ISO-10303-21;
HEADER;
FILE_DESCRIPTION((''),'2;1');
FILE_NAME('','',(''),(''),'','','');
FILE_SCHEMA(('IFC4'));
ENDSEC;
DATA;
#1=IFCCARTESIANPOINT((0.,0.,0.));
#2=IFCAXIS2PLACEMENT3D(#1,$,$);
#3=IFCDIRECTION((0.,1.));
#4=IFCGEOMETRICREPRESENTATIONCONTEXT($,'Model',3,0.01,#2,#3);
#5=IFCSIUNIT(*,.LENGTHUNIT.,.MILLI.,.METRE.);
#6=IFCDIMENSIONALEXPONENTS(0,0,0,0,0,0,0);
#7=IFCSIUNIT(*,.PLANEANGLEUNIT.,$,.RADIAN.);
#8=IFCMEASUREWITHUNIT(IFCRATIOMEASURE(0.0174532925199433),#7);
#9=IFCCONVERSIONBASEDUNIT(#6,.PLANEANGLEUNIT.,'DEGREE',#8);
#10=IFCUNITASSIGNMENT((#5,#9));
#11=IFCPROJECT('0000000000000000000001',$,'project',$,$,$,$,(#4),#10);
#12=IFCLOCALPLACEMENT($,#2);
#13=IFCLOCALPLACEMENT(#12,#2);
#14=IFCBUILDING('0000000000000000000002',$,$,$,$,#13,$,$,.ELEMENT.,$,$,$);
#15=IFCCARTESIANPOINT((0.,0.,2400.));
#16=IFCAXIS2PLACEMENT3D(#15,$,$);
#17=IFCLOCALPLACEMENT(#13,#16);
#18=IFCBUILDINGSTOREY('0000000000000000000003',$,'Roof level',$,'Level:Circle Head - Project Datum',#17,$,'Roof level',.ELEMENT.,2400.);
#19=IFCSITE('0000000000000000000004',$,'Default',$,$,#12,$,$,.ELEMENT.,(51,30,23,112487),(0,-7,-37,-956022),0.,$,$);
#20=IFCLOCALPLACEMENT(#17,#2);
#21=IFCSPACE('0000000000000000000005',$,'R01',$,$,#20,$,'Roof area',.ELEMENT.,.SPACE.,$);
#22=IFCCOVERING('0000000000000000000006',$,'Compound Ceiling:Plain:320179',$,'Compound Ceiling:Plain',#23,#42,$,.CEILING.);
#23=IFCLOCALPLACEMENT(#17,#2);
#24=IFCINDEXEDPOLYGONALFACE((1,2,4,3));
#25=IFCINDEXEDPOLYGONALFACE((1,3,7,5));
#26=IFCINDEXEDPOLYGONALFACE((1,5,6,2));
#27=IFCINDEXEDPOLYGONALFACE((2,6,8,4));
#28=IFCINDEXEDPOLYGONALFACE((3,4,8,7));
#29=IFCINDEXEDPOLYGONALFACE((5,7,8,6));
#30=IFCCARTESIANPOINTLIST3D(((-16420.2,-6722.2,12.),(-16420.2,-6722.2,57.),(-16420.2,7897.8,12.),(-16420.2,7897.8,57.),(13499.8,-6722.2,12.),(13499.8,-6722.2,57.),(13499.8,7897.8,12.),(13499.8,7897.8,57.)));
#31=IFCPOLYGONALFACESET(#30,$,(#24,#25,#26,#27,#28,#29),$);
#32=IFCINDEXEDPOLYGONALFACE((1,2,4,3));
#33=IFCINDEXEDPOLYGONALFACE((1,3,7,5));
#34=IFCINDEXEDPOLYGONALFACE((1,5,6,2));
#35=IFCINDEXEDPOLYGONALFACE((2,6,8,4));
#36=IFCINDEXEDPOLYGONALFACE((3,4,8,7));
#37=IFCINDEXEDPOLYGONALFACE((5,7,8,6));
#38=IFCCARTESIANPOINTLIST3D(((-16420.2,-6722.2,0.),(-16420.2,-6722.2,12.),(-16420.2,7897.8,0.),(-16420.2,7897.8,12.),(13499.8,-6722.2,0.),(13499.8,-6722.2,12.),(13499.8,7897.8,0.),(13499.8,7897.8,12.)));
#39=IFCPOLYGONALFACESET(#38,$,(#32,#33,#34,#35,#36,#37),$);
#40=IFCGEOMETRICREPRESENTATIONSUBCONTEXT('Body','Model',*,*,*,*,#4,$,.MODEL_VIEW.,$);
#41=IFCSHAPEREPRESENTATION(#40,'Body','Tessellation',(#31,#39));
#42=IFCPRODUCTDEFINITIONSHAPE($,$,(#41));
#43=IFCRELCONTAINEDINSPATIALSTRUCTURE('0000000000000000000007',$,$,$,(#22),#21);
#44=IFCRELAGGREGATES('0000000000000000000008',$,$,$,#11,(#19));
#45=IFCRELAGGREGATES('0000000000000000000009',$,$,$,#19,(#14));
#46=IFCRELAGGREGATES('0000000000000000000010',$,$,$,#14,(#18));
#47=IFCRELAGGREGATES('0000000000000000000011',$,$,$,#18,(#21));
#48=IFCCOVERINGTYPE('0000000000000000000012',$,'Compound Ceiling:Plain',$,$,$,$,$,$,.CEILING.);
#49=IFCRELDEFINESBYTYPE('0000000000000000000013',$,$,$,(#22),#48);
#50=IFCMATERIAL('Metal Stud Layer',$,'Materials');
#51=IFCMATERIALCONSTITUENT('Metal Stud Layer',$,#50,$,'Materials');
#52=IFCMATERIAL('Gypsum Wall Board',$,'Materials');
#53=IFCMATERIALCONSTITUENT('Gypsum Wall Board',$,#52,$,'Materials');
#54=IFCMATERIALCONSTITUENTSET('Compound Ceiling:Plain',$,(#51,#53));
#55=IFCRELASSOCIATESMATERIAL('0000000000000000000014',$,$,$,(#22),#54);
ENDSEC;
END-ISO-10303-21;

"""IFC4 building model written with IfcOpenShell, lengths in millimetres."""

from ifc_helpers import new_model, entity, si_unit, converted_unit, direction, frame, origin, place, context, subcontext, project, spatial, indexed_curve, outline, extrude, material, constituent, constituent_set, type_object, element, save


model = new_model("IFC4")

# Units and contexts
model_context = context("Model", 3, precision=0.01, world=origin(), true_north=direction((0.0, 1.0)))
body_context = subcontext(model_context, "Body", "Model", "MODEL_VIEW")
ifc_project = project(units=[si_unit("LENGTHUNIT", "METRE", prefix="MILLI"), converted_unit("PLANEANGLEUNIT", "DEGREE", entity("IfcRatioMeasure", 0.0174532925199433), si_unit("PLANEANGLEUNIT", "RADIAN"), dimensions=[0, 0, 0, 0, 0, 0, 0])], contexts=[model_context])

# Site, building, storey, space
site_placement = place(None, origin())
site = spatial("IfcSite", under=ifc_project, at=site_placement, Name="Default", CompositionType="ELEMENT", RefLatitude=(51, 30, 23, 112487), RefLongitude=(0, -7, -37, -956022), RefElevation=0.0)
building_placement = place(site_placement, origin())
building = spatial("IfcBuilding", under=site, at=building_placement, CompositionType="ELEMENT")
storey_placement = place(building_placement, frame((0.0, 0.0, 2400.0)))
storey = spatial("IfcBuildingStorey", under=building, at=storey_placement, Name="Roof level", ObjectType="Level:Circle Head - Project Datum", LongName="Roof level", CompositionType="ELEMENT", Elevation=2400.0)
space_placement = place(storey_placement, origin())
space = spatial("IfcSpace", under=storey, at=space_placement, Name="R01", LongName="Roof area", CompositionType="ELEMENT", PredefinedType="SPACE")

# Covering
ifc_material_1 = material(Name="Metal Stud Layer", Category="Materials")
ifc_constituent_1 = constituent(ifc_material_1, Name="Metal Stud Layer", Category="Materials")
ifc_material_2 = material(Name="Gypsum Wall Board", Category="Materials")
ifc_constituent_2 = constituent(ifc_material_2, Name="Gypsum Wall Board", Category="Materials")
ifc_constituent_set = constituent_set(constituents=[ifc_constituent_1, ifc_constituent_2], Name="Compound Ceiling:Plain")
covering_type = type_object("IfcCoveringType", Name="Compound Ceiling:Plain", PredefinedType="CEILING")
covering_placement = place(space_placement, frame((0.0, 0.0, -2400.0)))
element("IfcCovering", 1, at=covering_placement, inside=space, type_object=covering_type, material=ifc_constituent_set, Name="Compound Ceiling:Plain:320179", ObjectType="Compound Ceiling:Plain", PredefinedType="CEILING", context=body_context, shape_type="SweptSolid", body=[
    extrude(outline(indexed_curve([(-14960.0, -7310.0), (14960.0, -7310.0), (14960.0, 7310.0), (-14960.0, 7310.0), (-14960.0, -7310.0)], self_intersect=False)), frame((-1460.2, 587.8, 2412.0)), (0.0, 0.0, 1.0), 45.0),
    extrude(outline(indexed_curve([(-7310.0, -14960.0), (7310.0, -14960.0), (7310.0, 14960.0), (-7310.0, 14960.0), (-7310.0, -14960.0)], self_intersect=False)), frame((-1460.2, 587.8, 2400.0), z_axis=(0.0, 0.0, 1.0), x_axis=(0.0, -1.0, 0.0)), (0.0, 0.0, 1.0), 12.0),
])

save(model, "model.ifc")
